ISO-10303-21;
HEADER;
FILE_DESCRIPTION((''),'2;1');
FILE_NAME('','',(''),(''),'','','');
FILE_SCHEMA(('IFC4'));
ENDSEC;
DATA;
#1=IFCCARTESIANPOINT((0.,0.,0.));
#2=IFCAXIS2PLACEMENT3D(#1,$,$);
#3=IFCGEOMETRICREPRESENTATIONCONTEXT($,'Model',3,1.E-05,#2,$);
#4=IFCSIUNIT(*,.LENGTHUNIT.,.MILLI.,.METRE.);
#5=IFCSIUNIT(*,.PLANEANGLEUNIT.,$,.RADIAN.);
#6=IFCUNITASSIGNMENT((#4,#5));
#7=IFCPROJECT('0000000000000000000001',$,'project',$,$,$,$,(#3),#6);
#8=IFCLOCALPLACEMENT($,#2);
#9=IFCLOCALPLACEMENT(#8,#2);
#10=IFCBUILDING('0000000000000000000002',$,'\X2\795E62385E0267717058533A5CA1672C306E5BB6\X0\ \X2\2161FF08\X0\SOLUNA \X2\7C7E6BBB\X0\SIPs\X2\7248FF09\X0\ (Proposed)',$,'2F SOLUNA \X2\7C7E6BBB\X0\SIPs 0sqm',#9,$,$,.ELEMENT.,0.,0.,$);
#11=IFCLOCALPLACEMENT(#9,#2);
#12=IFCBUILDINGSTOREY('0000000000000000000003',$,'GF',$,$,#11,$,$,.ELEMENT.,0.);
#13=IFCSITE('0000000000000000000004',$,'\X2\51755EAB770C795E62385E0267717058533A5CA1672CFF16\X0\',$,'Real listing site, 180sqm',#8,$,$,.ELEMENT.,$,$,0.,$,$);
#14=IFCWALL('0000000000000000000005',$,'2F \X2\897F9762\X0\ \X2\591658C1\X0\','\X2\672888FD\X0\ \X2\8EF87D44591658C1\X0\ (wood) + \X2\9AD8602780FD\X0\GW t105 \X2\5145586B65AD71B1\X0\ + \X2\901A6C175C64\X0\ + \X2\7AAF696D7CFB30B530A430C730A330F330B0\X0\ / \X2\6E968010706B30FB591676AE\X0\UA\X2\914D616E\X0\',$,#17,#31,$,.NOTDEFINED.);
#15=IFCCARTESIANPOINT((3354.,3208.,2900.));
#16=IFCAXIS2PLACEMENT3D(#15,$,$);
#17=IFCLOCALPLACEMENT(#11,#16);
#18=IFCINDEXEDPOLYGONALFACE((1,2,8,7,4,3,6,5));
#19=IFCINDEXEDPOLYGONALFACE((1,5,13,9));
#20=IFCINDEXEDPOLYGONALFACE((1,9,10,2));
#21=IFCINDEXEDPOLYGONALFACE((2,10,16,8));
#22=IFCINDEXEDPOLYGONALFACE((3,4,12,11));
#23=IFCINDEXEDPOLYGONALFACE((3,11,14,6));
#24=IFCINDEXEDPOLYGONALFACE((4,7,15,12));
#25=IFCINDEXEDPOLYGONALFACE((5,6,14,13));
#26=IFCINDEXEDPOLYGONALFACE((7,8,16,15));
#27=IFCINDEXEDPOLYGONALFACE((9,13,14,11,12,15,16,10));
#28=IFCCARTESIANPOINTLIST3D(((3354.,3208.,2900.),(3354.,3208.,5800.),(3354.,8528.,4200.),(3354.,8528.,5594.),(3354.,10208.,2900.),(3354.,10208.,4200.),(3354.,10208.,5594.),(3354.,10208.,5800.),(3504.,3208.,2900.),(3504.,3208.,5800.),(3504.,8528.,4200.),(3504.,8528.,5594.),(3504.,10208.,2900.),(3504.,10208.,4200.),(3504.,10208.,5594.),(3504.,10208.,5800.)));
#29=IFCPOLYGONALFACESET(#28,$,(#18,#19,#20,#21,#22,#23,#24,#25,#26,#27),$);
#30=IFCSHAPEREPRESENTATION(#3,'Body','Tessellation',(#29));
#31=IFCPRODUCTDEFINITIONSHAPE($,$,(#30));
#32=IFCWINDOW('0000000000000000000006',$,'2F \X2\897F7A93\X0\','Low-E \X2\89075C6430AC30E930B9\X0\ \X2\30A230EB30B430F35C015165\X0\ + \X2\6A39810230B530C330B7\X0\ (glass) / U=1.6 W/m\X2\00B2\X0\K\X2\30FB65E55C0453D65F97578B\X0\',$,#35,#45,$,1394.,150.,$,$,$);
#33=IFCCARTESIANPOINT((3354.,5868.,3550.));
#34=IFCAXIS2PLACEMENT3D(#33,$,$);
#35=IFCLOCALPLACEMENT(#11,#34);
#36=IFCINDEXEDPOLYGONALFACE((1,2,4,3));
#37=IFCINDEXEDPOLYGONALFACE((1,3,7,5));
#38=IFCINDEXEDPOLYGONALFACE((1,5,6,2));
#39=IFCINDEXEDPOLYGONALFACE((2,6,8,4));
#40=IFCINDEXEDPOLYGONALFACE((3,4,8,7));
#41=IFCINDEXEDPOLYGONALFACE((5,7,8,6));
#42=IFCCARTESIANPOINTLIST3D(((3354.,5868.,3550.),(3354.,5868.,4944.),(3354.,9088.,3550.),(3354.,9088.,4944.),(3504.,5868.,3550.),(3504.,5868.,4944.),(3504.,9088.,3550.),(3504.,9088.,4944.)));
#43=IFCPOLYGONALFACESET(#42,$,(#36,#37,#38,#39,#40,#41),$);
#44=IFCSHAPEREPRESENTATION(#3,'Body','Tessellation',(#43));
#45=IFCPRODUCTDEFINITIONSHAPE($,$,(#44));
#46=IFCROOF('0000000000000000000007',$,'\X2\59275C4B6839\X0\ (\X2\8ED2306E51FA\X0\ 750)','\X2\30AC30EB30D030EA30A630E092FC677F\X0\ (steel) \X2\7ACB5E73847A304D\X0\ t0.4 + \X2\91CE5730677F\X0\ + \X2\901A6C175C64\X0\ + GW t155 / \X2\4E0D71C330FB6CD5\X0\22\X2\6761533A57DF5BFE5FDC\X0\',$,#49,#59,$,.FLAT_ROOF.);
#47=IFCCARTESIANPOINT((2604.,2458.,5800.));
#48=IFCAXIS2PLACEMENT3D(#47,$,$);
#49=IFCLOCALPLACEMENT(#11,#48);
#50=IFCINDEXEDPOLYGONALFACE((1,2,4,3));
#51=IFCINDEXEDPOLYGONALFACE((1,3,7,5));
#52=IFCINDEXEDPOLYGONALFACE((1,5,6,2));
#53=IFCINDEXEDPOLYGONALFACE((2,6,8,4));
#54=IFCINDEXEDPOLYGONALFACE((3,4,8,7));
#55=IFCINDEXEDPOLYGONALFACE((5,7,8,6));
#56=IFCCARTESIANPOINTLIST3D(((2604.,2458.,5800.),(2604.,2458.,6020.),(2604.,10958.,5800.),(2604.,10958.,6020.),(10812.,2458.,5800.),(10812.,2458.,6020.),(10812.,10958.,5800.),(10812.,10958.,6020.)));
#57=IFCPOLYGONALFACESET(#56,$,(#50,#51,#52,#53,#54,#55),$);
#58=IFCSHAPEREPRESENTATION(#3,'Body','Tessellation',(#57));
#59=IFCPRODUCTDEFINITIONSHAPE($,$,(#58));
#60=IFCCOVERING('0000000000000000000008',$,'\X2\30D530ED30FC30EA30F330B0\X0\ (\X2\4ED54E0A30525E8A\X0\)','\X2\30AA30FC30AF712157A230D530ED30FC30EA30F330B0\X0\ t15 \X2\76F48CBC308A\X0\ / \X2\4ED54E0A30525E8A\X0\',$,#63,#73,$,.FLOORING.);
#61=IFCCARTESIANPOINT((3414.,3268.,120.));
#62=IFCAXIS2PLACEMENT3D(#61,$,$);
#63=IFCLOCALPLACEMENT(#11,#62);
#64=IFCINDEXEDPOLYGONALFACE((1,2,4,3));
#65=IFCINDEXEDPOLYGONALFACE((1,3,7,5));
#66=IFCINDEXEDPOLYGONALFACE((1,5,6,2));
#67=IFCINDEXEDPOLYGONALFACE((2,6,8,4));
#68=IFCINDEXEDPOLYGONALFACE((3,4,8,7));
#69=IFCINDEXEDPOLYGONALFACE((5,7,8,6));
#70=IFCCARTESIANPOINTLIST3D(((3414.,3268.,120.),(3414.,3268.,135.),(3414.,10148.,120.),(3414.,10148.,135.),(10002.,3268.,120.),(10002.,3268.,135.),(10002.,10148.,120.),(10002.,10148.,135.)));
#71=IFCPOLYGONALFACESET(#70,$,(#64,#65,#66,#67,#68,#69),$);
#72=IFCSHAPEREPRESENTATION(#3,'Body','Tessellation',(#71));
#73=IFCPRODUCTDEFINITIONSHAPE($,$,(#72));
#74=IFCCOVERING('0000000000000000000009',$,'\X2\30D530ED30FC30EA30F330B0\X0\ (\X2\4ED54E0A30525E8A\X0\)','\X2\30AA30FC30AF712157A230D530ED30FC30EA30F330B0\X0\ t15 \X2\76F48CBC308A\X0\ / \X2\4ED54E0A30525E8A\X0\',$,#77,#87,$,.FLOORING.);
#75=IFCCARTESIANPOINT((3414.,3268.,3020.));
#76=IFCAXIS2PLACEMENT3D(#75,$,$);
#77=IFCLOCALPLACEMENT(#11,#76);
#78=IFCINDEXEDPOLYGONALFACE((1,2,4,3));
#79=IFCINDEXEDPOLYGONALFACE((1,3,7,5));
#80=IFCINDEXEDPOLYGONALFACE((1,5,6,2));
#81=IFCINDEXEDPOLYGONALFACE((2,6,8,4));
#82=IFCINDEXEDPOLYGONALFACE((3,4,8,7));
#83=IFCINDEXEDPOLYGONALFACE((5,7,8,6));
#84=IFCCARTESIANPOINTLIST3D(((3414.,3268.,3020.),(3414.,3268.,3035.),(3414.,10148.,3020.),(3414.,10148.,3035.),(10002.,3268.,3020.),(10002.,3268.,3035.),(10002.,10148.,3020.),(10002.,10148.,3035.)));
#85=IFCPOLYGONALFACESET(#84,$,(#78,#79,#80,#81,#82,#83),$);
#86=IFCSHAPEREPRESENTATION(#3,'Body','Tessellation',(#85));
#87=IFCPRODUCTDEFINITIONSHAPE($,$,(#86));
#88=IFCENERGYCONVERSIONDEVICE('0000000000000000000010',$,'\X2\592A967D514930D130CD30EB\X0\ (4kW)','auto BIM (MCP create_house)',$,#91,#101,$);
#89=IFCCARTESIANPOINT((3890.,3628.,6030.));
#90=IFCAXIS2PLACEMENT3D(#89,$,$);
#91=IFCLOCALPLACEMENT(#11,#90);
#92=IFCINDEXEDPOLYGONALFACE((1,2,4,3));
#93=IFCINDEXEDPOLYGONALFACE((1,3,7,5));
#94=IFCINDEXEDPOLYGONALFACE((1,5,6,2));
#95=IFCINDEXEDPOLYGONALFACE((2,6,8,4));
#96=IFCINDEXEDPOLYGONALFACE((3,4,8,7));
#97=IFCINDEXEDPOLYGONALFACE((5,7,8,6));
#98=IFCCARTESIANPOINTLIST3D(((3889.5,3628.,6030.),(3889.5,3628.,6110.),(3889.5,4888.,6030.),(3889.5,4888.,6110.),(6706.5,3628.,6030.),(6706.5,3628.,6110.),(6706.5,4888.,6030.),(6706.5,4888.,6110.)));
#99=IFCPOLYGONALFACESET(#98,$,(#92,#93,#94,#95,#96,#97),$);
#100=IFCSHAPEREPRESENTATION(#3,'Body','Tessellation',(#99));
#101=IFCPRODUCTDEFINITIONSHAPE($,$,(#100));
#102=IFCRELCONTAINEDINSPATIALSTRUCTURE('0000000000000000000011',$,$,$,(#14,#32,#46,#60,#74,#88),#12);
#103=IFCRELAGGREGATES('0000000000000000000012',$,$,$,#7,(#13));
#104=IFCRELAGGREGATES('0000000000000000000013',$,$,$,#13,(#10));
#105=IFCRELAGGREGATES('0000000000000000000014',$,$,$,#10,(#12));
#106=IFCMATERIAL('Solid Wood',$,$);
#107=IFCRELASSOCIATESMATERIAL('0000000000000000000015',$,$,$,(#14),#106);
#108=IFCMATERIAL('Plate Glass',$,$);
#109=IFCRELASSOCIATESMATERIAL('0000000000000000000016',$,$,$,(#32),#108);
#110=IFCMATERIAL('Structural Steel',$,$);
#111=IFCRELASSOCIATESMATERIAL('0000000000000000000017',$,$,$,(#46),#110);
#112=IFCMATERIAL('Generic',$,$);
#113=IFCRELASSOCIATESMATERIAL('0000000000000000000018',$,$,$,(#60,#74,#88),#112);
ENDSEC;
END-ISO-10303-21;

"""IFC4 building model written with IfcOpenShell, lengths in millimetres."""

from ifc_helpers import new_model, si_unit, frame, frame_2d, origin, place, context, project, spatial, rectangle, extrude, material, element, fill, save


model = new_model("IFC4")

# Units and contexts
model_context = context("Model", 3, precision=1e-05, world=origin())
ifc_project = project(units=[si_unit("LENGTHUNIT", "METRE", prefix="MILLI"), si_unit("PLANEANGLEUNIT", "RADIAN")], contexts=[model_context])

# Site, building, storey
site_placement = place(None, origin())
site = spatial("IfcSite", under=ifc_project, at=site_placement, Name="兵庫県神戸市東灘区岡本６", ObjectType="Real listing site, 180sqm", CompositionType="ELEMENT", RefElevation=0.0)
building_placement = place(site_placement, origin())
building = spatial("IfcBuilding", under=site, at=building_placement, Name="神戸市東灘区岡本の家 Ⅱ（SOLUNA 籾殻SIPs版） (Proposed)", ObjectType="2F SOLUNA 籾殻SIPs 0sqm", CompositionType="ELEMENT", ElevationOfRefHeight=0.0, ElevationOfTerrain=0.0)
storey_placement = place(building_placement, origin())
storey = spatial("IfcBuildingStorey", under=building, at=storey_placement, Name="GF", CompositionType="ELEMENT", Elevation=0.0)

# Shared definitions
ifc_material_1 = material(Name="Solid Wood")

# Shared definitions
ifc_material_2 = material(Name="Plate Glass")

# Wall, opening, window
wall_1_placement = place(storey_placement, frame((3354.0, 3208.0, 2900.0)))
wall_1 = element("IfcWall", 1, at=wall_1_placement, inside=storey, material=ifc_material_1, Name="2F 西面 外壁", Description="木製 軸組外壁 (wood) + 高性能GW t105 充填断熱 + 通気層 + 窯業系サイディング / 準耐火・外皮UA配慮", PredefinedType="NOTDEFINED", context=model_context, shape_type="SweptSolid", body=[
    extrude(rectangle(XDim=150.0, YDim=7000.0, at=frame_2d((75.0, 3500.0))), frame((3354.0, 3208.0, 2900.0)), (0.0, 0.0, 1.0), 2900.0),
])
opening_1_placement = place(storey_placement, frame((3354.0, 5868.0, 3550.0)))
opening_1 = element("IfcOpeningElement", 2, at=opening_1_placement, cuts=wall_1, PredefinedType="NOTDEFINED", context=model_context, shape_type="SweptSolid", body=[
    extrude(rectangle(XDim=150.0, YDim=3220.0, at=frame_2d((75.0, 1610.0))), frame((3354.0, 5868.0, 3550.0)), (0.0, 0.0, 1.0), 1394.0),
])
window_1_placement = place(storey_placement, frame((3354.0, 5868.0, 3550.0)))
window_1 = element("IfcWindow", 3, at=window_1_placement, inside=storey, material=ifc_material_2, Name="2F 西窓", Description="Low-E 複層ガラス アルゴン封入 + 樹脂サッシ (glass) / U=1.6 W/m²K・日射取得型", OverallHeight=1394.0, OverallWidth=150.0, context=model_context, shape_type="SweptSolid", body=[
    extrude(rectangle(XDim=150.0, YDim=3220.0, at=frame_2d((75.0, 1610.0))), frame((3354.0, 5868.0, 3550.0)), (0.0, 0.0, 1.0), 1394.0),
])
fill(opening_1, window_1)

# Roof
ifc_material_3 = material(Name="Structural Steel")
roof_placement = place(storey_placement, frame((2604.0, 2458.0, 5800.0)))
element("IfcRoof", 4, at=roof_placement, inside=storey, material=ifc_material_3, Name="大屋根 (軒の出 750)", Description="ガルバリウム鋼板 (steel) 立平葺き t0.4 + 野地板 + 通気層 + GW t155 / 不燃・法22条区域対応", PredefinedType="FLAT_ROOF", context=model_context, shape_type="SweptSolid", body=[
    extrude(rectangle(XDim=8208.0, YDim=8500.0, at=frame_2d((4104.0, 4250.0))), frame((2604.0, 2458.0, 5800.0)), (0.0, 0.0, 1.0), 220.0),
])

# Coverings
ifc_material_4 = material(Name="Generic")
covering_1_placement = place(storey_placement, frame((3414.0, 3268.0, 120.0)))
element("IfcCovering", 5, at=covering_1_placement, inside=storey, material=ifc_material_4, Name="フローリング (仕上げ床)", Description="オーク無垢フローリング t15 直貼り / 仕上げ床", PredefinedType="FLOORING", context=model_context, shape_type="SweptSolid", body=[
    extrude(rectangle(XDim=6588.0, YDim=6880.0, at=frame_2d((3294.0, 3440.0))), frame((3414.0, 3268.0, 120.0)), (0.0, 0.0, 1.0), 15.0),
])
covering_2_placement = place(storey_placement, frame((3414.0, 3268.0, 3020.0)))
element("IfcCovering", 6, at=covering_2_placement, inside=storey, material=ifc_material_4, Name="フローリング (仕上げ床)", Description="オーク無垢フローリング t15 直貼り / 仕上げ床", PredefinedType="FLOORING", context=model_context, shape_type="SweptSolid", body=[
    extrude(rectangle(XDim=6588.0, YDim=6880.0, at=frame_2d((3294.0, 3440.0))), frame((3414.0, 3268.0, 3020.0)), (0.0, 0.0, 1.0), 15.0),
])

# Energy conversion device
energy_conversion_device_placement = place(storey_placement, frame((3890.0, 3628.0, 6030.0)))
element("IfcEnergyConversionDevice", 7, at=energy_conversion_device_placement, inside=storey, material=ifc_material_4, Name="太陽光パネル (4kW)", Description="auto BIM (MCP create_house)", context=model_context, shape_type="SweptSolid", body=[
    extrude(rectangle(XDim=2817.0, YDim=1260.0, at=frame_2d((1408.0, 630.0))), frame((3890.0, 3628.0, 6030.0)), (0.0, 0.0, 1.0), 80.0),
])

save(model, "model.ifc")
